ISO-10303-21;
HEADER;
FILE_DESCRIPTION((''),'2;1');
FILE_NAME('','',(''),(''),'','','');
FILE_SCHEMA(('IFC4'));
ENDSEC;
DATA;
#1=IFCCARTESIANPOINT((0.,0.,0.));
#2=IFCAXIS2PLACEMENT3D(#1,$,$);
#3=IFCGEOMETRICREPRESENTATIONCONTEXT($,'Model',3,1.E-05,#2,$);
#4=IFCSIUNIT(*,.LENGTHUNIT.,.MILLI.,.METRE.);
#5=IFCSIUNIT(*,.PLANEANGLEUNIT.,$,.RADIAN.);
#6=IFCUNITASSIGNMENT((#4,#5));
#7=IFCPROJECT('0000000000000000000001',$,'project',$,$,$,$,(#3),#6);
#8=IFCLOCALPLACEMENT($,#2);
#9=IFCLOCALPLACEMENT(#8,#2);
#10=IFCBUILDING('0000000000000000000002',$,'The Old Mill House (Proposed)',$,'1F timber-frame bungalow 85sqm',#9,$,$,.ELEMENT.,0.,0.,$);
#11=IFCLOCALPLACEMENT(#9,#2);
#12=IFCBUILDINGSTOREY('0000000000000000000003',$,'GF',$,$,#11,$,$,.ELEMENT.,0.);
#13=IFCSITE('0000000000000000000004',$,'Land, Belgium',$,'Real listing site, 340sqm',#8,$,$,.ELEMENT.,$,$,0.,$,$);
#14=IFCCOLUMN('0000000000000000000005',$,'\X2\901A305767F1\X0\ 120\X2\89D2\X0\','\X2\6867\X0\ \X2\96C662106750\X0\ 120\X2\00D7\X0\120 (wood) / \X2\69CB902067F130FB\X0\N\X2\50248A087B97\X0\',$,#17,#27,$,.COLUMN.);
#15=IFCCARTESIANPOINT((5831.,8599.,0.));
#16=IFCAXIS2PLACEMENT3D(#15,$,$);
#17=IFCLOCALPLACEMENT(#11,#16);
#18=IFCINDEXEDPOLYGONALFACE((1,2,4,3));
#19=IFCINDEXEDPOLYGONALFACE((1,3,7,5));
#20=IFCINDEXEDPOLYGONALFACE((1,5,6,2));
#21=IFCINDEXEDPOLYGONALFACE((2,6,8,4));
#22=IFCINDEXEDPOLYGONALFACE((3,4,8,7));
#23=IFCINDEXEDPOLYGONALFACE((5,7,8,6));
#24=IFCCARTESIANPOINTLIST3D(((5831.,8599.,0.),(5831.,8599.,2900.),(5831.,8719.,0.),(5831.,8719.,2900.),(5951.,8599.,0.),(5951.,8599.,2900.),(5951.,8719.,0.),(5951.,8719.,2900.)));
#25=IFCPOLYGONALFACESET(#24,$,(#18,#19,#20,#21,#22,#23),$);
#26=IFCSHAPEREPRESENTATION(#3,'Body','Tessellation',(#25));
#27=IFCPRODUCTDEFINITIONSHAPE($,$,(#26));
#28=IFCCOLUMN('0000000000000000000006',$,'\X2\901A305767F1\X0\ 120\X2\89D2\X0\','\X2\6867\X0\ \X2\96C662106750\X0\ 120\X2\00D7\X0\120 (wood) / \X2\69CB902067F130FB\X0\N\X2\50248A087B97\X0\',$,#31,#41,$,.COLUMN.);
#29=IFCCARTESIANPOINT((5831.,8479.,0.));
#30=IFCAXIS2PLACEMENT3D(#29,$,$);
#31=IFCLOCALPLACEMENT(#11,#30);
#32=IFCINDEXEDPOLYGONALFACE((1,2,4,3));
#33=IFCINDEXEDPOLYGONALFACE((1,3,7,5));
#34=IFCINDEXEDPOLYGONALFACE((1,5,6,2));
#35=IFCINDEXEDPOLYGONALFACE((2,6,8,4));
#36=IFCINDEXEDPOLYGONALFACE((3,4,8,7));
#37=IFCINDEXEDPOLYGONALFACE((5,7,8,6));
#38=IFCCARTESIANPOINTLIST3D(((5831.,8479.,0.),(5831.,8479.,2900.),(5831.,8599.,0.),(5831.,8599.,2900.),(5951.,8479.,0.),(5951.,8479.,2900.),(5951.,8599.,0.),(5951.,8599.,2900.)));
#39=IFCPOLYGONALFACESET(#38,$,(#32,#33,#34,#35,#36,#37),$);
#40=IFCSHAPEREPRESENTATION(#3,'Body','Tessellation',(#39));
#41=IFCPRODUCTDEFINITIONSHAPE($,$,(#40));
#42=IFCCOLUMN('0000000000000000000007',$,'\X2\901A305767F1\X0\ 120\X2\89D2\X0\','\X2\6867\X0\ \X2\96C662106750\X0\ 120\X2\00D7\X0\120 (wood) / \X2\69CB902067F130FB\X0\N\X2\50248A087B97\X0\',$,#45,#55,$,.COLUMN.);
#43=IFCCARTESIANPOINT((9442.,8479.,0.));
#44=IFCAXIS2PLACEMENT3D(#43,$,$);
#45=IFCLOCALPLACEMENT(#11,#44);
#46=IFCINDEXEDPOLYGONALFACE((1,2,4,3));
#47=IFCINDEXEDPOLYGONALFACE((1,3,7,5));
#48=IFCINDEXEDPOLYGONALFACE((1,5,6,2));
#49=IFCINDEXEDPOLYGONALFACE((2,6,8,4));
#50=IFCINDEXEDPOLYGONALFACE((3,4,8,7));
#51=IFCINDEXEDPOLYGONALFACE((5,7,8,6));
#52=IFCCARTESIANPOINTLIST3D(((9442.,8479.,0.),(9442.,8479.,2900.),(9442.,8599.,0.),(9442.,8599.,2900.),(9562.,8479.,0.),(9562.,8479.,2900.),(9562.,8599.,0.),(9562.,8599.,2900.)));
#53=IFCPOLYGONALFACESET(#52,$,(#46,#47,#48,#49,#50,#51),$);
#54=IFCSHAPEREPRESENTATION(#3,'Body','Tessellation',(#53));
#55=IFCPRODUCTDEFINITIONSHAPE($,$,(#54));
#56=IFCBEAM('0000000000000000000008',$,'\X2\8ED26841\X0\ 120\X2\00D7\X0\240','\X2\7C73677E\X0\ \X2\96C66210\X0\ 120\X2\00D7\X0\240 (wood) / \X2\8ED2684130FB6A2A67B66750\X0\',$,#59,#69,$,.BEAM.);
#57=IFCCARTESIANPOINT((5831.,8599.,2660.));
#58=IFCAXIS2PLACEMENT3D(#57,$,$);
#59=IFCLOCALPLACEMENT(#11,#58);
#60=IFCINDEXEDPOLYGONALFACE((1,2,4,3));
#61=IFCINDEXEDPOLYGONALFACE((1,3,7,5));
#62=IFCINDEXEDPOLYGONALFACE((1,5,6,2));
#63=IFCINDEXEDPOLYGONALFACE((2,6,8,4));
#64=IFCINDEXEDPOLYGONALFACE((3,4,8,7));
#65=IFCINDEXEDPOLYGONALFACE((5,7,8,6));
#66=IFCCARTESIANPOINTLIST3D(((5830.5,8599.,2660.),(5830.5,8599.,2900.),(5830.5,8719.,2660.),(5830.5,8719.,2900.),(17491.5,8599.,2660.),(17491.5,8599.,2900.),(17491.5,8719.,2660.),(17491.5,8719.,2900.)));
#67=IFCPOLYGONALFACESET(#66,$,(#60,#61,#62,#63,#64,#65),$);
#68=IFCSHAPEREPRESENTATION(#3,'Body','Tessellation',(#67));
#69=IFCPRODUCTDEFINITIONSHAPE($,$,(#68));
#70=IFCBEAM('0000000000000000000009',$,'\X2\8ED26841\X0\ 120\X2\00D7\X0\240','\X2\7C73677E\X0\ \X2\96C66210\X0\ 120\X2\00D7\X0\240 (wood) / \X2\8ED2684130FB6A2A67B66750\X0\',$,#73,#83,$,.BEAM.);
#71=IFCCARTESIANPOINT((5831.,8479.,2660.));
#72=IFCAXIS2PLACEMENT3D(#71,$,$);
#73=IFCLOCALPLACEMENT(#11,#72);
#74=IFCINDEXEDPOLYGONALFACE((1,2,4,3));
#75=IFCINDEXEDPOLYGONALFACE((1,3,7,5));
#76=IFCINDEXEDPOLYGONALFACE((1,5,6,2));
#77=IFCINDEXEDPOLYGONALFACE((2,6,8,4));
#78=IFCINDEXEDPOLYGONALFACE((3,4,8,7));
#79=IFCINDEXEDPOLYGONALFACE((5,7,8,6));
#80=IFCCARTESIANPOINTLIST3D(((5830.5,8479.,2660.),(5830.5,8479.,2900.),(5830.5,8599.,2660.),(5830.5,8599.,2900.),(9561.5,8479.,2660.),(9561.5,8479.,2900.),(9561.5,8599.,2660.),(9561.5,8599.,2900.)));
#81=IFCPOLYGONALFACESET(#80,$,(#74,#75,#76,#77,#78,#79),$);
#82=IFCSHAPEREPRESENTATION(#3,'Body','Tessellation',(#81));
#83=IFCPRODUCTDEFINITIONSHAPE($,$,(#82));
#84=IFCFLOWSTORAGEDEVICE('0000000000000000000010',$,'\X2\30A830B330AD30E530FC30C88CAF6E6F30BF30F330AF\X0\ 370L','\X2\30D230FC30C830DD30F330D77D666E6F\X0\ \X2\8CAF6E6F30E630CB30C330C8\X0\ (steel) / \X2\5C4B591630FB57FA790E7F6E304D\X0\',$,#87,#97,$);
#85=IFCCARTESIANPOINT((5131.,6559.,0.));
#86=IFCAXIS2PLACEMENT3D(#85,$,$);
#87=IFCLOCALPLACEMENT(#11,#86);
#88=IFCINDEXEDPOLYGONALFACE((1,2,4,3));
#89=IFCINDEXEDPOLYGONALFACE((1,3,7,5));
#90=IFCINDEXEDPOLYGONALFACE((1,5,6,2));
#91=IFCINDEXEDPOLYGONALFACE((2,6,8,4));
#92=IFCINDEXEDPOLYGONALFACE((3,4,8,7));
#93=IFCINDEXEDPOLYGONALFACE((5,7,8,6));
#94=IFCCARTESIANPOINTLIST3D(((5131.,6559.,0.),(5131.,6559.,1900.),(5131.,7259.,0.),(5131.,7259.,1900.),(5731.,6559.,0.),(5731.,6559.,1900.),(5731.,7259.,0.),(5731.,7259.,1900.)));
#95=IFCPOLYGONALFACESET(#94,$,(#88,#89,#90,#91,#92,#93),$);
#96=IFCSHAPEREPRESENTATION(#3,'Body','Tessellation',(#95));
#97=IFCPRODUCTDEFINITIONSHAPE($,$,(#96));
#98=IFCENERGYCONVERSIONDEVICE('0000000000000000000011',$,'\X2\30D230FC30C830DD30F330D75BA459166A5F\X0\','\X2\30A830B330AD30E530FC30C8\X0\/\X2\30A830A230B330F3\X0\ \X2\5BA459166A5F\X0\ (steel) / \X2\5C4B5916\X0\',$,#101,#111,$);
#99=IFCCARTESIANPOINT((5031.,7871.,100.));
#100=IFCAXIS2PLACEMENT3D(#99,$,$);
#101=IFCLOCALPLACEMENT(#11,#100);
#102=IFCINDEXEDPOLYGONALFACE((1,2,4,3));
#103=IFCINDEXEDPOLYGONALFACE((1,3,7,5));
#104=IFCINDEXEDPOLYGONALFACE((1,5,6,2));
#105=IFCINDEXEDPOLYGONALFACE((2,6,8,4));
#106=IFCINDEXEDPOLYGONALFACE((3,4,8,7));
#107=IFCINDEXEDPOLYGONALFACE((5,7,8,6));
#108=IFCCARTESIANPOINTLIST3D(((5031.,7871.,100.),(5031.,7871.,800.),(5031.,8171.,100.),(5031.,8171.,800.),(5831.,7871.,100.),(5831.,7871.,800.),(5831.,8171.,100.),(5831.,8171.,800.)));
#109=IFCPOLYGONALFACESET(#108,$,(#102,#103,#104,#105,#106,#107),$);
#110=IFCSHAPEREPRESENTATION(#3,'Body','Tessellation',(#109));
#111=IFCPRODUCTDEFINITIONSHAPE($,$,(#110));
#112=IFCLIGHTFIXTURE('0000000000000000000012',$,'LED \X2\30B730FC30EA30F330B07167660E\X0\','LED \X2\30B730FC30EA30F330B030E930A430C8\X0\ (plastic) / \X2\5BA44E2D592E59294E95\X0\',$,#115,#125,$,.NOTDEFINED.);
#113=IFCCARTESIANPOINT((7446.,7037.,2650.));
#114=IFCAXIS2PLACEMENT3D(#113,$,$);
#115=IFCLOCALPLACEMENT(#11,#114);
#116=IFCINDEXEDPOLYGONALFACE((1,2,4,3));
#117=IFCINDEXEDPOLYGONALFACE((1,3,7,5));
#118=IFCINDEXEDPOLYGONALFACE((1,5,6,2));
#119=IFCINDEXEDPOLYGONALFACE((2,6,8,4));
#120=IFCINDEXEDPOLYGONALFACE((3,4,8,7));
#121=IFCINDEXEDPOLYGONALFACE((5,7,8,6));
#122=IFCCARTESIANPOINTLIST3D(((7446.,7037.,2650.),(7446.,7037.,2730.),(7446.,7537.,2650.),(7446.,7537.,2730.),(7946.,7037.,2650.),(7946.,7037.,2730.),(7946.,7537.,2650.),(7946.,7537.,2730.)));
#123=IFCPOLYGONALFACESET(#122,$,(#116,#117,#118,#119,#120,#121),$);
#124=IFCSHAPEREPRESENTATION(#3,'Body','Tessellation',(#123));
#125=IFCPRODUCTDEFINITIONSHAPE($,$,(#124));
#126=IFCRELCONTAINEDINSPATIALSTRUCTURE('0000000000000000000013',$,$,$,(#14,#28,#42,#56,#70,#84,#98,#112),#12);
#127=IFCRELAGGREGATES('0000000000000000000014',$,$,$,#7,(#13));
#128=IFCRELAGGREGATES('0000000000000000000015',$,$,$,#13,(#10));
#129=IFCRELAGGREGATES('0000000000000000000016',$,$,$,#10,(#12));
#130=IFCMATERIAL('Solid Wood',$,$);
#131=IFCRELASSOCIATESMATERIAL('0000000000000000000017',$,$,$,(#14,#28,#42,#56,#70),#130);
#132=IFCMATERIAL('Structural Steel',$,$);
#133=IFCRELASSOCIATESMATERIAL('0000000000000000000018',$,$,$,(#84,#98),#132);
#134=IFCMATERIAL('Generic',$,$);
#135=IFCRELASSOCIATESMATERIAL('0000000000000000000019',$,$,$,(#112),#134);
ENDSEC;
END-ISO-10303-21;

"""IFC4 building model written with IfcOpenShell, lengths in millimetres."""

from ifc_helpers import new_model, si_unit, frame, frame_2d, origin, place, context, project, spatial, rectangle, extrude, material, element, save


model = new_model("IFC4")

# Units and contexts
model_context = context("Model", 3, precision=1e-05, world=origin())
ifc_project = project(units=[si_unit("LENGTHUNIT", "METRE", prefix="MILLI"), si_unit("PLANEANGLEUNIT", "RADIAN")], contexts=[model_context])

# Site, building, storey
site_placement = place(None, origin())
site = spatial("IfcSite", under=ifc_project, at=site_placement, Name="Land, Belgium", ObjectType="Real listing site, 340sqm", CompositionType="ELEMENT", RefElevation=0.0)
building_placement = place(site_placement, origin())
building = spatial("IfcBuilding", under=site, at=building_placement, Name="The Old Mill House (Proposed)", ObjectType="1F timber-frame bungalow 85sqm", CompositionType="ELEMENT", ElevationOfRefHeight=0.0, ElevationOfTerrain=0.0)
storey_placement = place(building_placement, origin())
storey = spatial("IfcBuildingStorey", under=building, at=storey_placement, Name="GF", CompositionType="ELEMENT", Elevation=0.0)

# Columns
ifc_material_1 = material(Name="Solid Wood")
column_1_placement = place(storey_placement, frame((5831.0, 8599.0, 0.0)))
element("IfcColumn", 1, at=column_1_placement, inside=storey, material=ifc_material_1, Name="通し柱 120角", Description="桧 集成材 120×120 (wood) / 構造柱・N値計算", PredefinedType="COLUMN", context=model_context, shape_type="SweptSolid", body=[
    extrude(rectangle(XDim=120.0, YDim=120.0, at=frame_2d((60.0, 60.0))), frame((5831.0, 8599.0, 0.0)), (0.0, 0.0, 1.0), 2900.0),
])
column_2_placement = place(storey_placement, frame((5831.0, 8479.0, 0.0)))
element("IfcColumn", 2, at=column_2_placement, inside=storey, material=ifc_material_1, Name="通し柱 120角", Description="桧 集成材 120×120 (wood) / 構造柱・N値計算", PredefinedType="COLUMN", context=model_context, shape_type="SweptSolid", body=[
    extrude(rectangle(XDim=120.0, YDim=120.0, at=frame_2d((60.0, 60.0))), frame((5831.0, 8479.0, 0.0)), (0.0, 0.0, 1.0), 2900.0),
])
column_3_placement = place(storey_placement, frame((9442.0, 8479.0, 0.0)))
element("IfcColumn", 3, at=column_3_placement, inside=storey, material=ifc_material_1, Name="通し柱 120角", Description="桧 集成材 120×120 (wood) / 構造柱・N値計算", PredefinedType="COLUMN", context=model_context, shape_type="SweptSolid", body=[
    extrude(rectangle(XDim=120.0, YDim=120.0, at=frame_2d((60.0, 60.0))), frame((9442.0, 8479.0, 0.0)), (0.0, 0.0, 1.0), 2900.0),
])

# Beams
beam_1_placement = place(storey_placement, frame((5831.0, 8599.0, 2660.0)))
element("IfcBeam", 4, at=beam_1_placement, inside=storey, material=ifc_material_1, Name="軒桁 120×240", Description="米松 集成 120×240 (wood) / 軒桁・横架材", PredefinedType="BEAM", context=model_context, shape_type="SweptSolid", body=[
    extrude(rectangle(XDim=11661.0, YDim=120.0, at=frame_2d((5830.0, 60.0))), frame((5831.0, 8599.0, 2660.0)), (0.0, 0.0, 1.0), 240.0),
])
beam_2_placement = place(storey_placement, frame((5831.0, 8479.0, 2660.0)))
element("IfcBeam", 5, at=beam_2_placement, inside=storey, material=ifc_material_1, Name="軒桁 120×240", Description="米松 集成 120×240 (wood) / 軒桁・横架材", PredefinedType="BEAM", context=model_context, shape_type="SweptSolid", body=[
    extrude(rectangle(XDim=3731.0, YDim=120.0, at=frame_2d((1865.0, 60.0))), frame((5831.0, 8479.0, 2660.0)), (0.0, 0.0, 1.0), 240.0),
])

# Shared definitions
ifc_material_2 = material(Name="Structural Steel")

# Shared definitions
ifc_material_3 = material(Name="Generic")

# Flow storage device
flow_storage_device_placement = place(storey_placement, frame((5131.0, 6559.0, 0.0)))
element("IfcFlowStorageDevice", 6, at=flow_storage_device_placement, inside=storey, material=ifc_material_2, Name="エコキュート貯湯タンク 370L", Description="ヒートポンプ給湯 貯湯ユニット (steel) / 屋外・基礎置き", context=model_context, shape_type="SweptSolid", body=[
    extrude(rectangle(XDim=600.0, YDim=700.0, at=frame_2d((300.0, 350.0))), frame((5131.0, 6559.0, 0.0)), (0.0, 0.0, 1.0), 1900.0),
])

# Energy conversion device
energy_conversion_device_placement = place(storey_placement, frame((5031.0, 7871.0, 100.0)))
element("IfcEnergyConversionDevice", 7, at=energy_conversion_device_placement, inside=storey, material=ifc_material_2, Name="ヒートポンプ室外機", Description="エコキュート/エアコン 室外機 (steel) / 屋外", context=model_context, shape_type="SweptSolid", body=[
    extrude(rectangle(XDim=800.0, YDim=300.0, at=frame_2d((400.0, 150.0))), frame((5031.0, 7871.0, 100.0)), (0.0, 0.0, 1.0), 700.0),
])

# Light fixture
light_fixture_placement = place(storey_placement, frame((7446.0, 7037.0, 2650.0)))
element("IfcLightFixture", 8, at=light_fixture_placement, inside=storey, material=ifc_material_3, Name="LED シーリング照明", Description="LED シーリングライト (plastic) / 室中央天井", PredefinedType="NOTDEFINED", context=model_context, shape_type="SweptSolid", body=[
    extrude(rectangle(XDim=500.0, YDim=500.0, at=frame_2d((250.0, 250.0))), frame((7446.0, 7037.0, 2650.0)), (0.0, 0.0, 1.0), 80.0),
])

save(model, "model.ifc")
